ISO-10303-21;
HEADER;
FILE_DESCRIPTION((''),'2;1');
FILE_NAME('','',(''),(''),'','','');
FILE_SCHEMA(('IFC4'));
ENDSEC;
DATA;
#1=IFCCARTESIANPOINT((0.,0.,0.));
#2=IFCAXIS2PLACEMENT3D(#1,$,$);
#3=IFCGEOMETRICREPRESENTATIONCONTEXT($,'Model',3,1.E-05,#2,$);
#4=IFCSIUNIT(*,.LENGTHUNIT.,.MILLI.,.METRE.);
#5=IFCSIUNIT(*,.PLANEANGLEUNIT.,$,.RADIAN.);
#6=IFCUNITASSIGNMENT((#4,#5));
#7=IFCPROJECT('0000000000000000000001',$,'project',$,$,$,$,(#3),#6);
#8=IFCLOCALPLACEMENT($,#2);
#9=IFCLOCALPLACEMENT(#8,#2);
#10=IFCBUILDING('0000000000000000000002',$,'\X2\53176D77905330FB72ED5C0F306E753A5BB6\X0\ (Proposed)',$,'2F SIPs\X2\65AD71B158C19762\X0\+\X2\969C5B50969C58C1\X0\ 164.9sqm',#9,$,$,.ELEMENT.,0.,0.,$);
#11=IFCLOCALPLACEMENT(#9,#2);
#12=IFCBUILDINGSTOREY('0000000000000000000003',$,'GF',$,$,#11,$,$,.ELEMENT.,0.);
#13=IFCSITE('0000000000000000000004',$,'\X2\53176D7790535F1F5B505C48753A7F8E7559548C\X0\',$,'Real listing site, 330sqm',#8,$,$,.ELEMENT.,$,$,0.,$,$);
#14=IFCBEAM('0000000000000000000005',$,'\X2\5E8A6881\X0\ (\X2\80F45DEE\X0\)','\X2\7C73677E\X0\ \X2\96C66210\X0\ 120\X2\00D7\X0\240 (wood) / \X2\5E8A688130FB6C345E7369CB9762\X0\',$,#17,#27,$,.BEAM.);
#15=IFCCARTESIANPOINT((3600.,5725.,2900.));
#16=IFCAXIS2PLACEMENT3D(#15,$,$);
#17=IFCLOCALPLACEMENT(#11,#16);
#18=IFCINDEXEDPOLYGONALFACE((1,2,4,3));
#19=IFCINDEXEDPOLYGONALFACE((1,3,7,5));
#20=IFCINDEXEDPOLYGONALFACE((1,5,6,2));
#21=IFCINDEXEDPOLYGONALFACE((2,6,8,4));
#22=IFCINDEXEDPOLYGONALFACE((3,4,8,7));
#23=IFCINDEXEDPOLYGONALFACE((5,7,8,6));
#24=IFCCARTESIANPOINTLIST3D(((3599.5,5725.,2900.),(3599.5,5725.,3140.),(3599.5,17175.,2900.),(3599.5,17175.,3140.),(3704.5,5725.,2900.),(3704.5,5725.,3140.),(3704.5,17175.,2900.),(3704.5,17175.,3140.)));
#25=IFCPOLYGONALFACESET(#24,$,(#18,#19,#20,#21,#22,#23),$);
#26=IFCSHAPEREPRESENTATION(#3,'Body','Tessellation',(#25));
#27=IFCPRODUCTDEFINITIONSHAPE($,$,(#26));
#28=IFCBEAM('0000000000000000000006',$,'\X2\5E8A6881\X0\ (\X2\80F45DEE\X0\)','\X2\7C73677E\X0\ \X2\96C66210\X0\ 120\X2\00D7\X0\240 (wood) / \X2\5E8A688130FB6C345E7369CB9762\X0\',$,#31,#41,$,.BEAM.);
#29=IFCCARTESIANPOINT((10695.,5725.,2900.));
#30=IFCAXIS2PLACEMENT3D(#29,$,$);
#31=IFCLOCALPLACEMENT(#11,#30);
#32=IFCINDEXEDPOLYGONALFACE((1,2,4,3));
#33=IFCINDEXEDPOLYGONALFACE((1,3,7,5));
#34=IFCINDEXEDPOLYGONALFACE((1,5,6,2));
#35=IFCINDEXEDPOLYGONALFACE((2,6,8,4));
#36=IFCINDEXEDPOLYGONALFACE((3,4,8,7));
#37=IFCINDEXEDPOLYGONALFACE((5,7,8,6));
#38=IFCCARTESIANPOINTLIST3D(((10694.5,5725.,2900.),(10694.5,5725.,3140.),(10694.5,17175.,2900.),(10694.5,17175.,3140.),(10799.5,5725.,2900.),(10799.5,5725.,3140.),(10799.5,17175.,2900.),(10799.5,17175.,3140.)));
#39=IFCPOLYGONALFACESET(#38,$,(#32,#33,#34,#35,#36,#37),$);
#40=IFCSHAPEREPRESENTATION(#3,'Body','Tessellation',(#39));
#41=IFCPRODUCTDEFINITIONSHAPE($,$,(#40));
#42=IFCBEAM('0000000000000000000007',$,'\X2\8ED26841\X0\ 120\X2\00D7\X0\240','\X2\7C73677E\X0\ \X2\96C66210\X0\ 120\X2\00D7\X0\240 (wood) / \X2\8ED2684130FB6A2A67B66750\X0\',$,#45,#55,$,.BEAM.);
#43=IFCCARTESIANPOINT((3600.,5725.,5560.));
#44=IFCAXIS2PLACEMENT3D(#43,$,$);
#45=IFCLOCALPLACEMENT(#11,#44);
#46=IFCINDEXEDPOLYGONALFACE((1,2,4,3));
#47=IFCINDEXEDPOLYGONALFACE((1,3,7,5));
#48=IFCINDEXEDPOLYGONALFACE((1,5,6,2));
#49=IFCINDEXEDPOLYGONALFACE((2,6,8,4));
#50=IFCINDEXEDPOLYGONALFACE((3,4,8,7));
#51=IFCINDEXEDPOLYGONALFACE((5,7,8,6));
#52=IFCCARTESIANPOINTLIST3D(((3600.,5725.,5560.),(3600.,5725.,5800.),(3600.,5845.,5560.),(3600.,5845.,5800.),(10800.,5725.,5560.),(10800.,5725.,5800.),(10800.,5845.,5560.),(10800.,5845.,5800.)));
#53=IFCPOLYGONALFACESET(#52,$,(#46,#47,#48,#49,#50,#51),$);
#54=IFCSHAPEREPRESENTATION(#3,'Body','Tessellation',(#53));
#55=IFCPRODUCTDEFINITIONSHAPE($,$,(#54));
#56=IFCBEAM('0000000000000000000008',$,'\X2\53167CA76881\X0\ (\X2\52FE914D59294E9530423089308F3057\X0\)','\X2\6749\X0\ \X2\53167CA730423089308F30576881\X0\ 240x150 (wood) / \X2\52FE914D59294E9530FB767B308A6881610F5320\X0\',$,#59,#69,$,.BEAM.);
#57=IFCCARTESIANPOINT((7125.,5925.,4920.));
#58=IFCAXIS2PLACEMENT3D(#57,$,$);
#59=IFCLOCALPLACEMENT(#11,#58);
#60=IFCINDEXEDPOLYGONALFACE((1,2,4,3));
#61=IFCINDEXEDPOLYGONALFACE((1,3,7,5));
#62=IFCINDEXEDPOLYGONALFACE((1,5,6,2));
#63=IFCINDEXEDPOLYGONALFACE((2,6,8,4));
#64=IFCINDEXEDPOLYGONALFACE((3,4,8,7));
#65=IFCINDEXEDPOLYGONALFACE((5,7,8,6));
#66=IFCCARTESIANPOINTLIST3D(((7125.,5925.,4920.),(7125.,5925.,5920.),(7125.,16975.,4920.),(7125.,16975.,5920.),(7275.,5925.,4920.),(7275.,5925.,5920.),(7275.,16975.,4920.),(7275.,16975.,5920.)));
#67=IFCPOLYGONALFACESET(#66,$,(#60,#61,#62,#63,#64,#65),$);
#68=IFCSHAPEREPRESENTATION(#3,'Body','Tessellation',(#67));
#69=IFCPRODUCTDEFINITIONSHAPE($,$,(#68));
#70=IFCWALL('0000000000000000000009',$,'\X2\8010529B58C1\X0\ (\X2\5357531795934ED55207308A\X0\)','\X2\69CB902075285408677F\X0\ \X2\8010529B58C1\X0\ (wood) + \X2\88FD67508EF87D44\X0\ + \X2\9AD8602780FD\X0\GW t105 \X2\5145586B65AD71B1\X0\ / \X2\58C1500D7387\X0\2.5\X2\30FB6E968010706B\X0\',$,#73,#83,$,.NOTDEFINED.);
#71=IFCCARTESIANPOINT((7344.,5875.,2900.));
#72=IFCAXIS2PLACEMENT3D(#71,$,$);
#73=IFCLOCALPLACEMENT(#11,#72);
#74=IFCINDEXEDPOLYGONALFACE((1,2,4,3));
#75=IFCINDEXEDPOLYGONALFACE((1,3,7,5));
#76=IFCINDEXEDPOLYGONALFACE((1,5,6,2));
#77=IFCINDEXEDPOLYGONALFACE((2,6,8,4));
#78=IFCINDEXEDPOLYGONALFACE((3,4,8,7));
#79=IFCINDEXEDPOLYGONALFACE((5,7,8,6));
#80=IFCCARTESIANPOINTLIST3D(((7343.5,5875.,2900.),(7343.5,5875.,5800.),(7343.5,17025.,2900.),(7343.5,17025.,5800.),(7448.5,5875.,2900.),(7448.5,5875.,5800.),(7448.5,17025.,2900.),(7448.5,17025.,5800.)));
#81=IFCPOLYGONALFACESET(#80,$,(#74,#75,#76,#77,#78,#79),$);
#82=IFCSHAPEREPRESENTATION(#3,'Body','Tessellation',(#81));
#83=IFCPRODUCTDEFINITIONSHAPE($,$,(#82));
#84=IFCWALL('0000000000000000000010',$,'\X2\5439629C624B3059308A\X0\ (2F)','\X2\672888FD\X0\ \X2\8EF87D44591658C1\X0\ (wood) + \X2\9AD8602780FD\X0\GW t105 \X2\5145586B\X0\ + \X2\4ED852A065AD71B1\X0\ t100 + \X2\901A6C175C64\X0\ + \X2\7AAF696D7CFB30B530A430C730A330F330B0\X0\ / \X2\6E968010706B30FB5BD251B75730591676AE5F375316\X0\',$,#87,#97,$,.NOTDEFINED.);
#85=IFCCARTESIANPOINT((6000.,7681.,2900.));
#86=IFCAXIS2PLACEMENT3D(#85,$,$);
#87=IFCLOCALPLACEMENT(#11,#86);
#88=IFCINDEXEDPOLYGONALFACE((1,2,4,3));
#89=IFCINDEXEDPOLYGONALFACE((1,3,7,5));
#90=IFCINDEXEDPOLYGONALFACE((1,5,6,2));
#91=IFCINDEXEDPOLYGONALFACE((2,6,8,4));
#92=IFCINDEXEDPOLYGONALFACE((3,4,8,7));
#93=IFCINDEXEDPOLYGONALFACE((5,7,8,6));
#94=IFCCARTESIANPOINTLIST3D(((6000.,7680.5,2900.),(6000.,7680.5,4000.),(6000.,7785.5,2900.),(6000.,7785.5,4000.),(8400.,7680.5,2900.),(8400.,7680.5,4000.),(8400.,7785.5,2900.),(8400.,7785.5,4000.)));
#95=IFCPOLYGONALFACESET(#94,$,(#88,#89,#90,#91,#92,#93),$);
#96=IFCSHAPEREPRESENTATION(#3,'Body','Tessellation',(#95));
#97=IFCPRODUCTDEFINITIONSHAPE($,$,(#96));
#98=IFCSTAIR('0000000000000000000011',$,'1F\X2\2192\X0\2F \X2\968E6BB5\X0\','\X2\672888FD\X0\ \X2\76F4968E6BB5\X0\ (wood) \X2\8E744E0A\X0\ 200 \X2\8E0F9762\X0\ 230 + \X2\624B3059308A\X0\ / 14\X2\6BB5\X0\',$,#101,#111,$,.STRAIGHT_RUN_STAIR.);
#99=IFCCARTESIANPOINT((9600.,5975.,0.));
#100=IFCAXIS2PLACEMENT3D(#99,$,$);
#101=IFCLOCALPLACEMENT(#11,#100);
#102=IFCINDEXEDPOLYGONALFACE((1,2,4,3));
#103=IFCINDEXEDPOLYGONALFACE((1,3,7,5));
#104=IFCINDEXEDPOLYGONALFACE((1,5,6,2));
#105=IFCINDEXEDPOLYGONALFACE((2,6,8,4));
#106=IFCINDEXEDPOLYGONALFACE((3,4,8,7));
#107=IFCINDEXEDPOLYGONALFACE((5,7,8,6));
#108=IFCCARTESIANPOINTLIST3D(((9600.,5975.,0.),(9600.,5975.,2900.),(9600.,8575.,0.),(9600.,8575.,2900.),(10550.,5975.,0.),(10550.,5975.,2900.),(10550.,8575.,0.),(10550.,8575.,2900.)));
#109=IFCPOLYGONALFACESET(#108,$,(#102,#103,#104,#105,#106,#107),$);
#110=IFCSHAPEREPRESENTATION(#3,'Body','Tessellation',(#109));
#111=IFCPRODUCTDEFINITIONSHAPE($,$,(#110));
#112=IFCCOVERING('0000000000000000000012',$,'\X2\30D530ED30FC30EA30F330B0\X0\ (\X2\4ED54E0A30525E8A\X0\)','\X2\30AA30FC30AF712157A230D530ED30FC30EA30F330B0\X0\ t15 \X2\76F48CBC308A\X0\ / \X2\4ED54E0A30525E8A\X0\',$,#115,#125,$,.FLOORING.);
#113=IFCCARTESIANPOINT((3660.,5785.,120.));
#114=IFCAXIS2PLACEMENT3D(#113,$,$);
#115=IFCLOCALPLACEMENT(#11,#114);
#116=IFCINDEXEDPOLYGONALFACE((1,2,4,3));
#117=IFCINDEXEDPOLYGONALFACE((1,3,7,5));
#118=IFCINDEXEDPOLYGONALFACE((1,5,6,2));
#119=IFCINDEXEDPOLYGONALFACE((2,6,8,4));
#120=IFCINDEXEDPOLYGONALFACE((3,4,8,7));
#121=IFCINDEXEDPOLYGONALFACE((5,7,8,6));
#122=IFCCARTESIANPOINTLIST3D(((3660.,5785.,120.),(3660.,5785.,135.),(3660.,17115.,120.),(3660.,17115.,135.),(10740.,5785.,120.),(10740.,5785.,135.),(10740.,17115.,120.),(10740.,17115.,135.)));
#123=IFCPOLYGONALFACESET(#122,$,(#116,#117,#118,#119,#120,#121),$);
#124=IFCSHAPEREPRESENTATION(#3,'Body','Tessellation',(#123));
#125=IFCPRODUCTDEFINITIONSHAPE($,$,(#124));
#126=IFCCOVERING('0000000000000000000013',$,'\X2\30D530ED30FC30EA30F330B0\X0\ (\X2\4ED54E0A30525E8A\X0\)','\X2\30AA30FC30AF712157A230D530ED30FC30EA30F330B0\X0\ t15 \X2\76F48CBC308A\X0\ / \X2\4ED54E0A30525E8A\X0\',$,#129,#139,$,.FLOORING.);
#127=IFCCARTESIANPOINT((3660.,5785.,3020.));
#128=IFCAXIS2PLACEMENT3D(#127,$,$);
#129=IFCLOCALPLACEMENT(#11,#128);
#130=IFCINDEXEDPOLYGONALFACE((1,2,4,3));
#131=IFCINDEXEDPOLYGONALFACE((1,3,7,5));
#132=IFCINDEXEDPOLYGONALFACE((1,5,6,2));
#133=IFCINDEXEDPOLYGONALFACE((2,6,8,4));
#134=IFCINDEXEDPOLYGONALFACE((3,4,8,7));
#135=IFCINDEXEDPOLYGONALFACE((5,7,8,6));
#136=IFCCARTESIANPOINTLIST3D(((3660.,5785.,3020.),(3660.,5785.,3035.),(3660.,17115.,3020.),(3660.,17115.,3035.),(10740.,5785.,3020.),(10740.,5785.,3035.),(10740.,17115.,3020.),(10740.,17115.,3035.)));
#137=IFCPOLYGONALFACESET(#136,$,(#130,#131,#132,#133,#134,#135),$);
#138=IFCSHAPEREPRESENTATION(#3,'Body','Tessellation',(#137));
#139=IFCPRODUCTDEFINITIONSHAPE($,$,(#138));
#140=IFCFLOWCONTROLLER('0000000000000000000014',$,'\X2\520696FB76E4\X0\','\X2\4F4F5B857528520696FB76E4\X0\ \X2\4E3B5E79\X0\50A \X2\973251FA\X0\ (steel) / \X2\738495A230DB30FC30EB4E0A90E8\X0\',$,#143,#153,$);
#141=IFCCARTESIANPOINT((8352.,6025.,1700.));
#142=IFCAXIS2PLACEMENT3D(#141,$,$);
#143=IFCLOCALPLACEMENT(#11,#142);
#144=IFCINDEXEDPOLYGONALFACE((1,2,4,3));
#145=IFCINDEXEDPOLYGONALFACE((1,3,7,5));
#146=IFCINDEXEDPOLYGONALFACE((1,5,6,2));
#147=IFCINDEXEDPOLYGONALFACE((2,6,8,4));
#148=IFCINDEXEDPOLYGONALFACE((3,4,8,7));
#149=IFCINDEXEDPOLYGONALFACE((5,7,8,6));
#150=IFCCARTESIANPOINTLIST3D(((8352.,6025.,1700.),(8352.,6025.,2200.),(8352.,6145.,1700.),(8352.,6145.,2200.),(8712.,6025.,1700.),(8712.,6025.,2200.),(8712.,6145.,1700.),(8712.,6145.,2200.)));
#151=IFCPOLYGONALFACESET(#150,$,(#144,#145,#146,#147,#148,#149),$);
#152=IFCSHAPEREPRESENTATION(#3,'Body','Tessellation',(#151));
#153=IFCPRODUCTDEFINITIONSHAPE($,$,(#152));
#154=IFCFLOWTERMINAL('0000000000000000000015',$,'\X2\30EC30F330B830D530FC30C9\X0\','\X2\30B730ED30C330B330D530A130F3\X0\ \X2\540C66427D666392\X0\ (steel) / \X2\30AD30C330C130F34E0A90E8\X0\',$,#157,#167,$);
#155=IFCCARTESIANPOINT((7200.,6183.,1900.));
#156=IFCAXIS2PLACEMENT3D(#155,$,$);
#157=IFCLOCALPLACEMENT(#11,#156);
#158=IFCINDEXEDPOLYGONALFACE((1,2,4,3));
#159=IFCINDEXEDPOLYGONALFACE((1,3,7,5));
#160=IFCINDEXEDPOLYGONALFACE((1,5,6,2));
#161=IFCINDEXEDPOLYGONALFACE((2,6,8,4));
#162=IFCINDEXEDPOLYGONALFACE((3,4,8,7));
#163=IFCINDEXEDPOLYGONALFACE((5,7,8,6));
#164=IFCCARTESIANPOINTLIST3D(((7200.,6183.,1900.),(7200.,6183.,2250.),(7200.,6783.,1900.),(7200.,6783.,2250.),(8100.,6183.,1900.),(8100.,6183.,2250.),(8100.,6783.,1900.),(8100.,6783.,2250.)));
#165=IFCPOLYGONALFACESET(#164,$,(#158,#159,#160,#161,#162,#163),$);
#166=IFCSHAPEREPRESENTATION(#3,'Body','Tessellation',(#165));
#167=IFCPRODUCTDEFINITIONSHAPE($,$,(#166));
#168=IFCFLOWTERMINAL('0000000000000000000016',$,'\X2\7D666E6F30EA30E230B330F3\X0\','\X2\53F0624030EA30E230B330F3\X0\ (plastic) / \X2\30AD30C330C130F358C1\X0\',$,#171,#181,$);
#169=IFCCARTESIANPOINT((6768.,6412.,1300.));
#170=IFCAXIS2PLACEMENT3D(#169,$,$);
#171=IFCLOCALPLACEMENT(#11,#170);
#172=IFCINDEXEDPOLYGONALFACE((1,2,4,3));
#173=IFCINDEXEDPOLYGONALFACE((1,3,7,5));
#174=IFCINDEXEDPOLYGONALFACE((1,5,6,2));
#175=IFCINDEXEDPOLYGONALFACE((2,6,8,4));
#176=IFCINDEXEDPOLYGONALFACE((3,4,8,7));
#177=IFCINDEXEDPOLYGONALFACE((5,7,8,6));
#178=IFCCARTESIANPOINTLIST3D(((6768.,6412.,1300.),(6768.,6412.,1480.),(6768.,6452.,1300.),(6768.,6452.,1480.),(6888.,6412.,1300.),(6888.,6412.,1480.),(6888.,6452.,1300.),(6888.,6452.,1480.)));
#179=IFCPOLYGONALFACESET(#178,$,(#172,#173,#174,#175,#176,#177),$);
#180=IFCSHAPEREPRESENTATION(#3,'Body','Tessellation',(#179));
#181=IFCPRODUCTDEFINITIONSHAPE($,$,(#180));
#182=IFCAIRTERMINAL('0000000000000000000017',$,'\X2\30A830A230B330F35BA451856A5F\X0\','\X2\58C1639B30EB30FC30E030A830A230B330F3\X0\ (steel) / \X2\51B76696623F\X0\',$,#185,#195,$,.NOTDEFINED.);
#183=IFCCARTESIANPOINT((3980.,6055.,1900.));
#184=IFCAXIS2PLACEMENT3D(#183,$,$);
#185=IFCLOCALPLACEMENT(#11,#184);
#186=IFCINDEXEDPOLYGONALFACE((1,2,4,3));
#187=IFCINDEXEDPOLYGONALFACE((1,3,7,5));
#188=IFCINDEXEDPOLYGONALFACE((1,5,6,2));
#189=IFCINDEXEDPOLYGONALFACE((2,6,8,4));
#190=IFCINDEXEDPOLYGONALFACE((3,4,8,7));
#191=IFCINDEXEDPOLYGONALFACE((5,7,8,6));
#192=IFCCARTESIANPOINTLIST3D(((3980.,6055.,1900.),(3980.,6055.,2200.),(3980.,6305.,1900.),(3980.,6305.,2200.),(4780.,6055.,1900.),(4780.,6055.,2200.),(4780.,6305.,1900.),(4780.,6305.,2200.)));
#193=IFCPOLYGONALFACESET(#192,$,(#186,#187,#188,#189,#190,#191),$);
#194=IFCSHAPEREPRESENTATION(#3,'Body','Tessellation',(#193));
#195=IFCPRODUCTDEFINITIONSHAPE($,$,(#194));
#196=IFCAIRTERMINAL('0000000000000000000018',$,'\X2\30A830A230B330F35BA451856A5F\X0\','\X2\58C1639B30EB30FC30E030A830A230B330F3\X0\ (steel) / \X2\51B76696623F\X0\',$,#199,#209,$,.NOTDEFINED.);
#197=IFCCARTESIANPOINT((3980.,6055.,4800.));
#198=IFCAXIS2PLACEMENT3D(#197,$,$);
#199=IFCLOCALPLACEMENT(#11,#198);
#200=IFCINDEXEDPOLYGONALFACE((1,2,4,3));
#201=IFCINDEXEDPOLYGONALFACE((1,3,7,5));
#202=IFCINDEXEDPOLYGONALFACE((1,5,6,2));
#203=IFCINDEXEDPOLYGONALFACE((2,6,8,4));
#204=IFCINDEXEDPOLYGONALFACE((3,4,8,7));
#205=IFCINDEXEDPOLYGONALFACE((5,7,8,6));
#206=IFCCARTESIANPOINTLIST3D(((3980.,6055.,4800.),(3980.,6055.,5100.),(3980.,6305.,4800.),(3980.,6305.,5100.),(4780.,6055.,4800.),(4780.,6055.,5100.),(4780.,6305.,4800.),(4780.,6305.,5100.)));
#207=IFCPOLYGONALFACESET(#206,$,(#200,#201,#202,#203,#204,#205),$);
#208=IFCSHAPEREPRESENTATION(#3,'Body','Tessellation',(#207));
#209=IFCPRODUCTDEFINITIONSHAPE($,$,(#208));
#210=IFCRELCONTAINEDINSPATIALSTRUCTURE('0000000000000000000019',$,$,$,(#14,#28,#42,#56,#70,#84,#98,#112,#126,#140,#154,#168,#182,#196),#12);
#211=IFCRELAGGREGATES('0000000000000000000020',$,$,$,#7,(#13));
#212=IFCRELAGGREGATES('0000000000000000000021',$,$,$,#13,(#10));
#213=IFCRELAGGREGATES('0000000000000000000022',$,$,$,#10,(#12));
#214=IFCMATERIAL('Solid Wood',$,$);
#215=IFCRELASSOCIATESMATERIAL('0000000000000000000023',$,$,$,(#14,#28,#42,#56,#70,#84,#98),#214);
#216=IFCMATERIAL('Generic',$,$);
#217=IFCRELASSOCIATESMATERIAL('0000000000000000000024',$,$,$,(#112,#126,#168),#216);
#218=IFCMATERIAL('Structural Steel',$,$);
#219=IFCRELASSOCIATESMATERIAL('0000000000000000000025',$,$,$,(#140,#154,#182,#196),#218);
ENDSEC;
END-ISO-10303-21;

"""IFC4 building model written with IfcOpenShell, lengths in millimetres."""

from ifc_helpers import new_model, si_unit, frame, frame_2d, origin, place, context, project, spatial, rectangle, extrude, material, element, save


model = new_model("IFC4")

# Units and contexts
model_context = context("Model", 3, precision=1e-05, world=origin())
ifc_project = project(units=[si_unit("LENGTHUNIT", "METRE", prefix="MILLI"), si_unit("PLANEANGLEUNIT", "RADIAN")], contexts=[model_context])

# Site, building, storey
site_placement = place(None, origin())
site = spatial("IfcSite", under=ifc_project, at=site_placement, Name="北海道弟子屈町美留和", ObjectType="Real listing site, 330sqm", CompositionType="ELEMENT", RefElevation=0.0)
building_placement = place(site_placement, origin())
building = spatial("IfcBuilding", under=site, at=building_placement, Name="北海道・狭小の町家 (Proposed)", ObjectType="2F SIPs断熱壁面+障子障壁 164.9sqm", CompositionType="ELEMENT", ElevationOfRefHeight=0.0, ElevationOfTerrain=0.0)
storey_placement = place(building_placement, origin())
storey = spatial("IfcBuildingStorey", under=building, at=storey_placement, Name="GF", CompositionType="ELEMENT", Elevation=0.0)

# Shared definitions
ifc_material_1 = material(Name="Solid Wood")

# Beams
beam_1_placement = place(storey_placement, frame((3600.0, 5725.0, 2900.0)))
element("IfcBeam", 1, at=beam_1_placement, inside=storey, material=ifc_material_1, Name="床梁 (胴差)", Description="米松 集成 120×240 (wood) / 床梁・水平構面", PredefinedType="BEAM", context=model_context, shape_type="SweptSolid", body=[
    extrude(rectangle(XDim=105.0, YDim=11450.0, at=frame_2d((52.0, 5725.0))), frame((3600.0, 5725.0, 2900.0)), (0.0, 0.0, 1.0), 240.0),
])
beam_2_placement = place(storey_placement, frame((10695.0, 5725.0, 2900.0)))
element("IfcBeam", 2, at=beam_2_placement, inside=storey, material=ifc_material_1, Name="床梁 (胴差)", Description="米松 集成 120×240 (wood) / 床梁・水平構面", PredefinedType="BEAM", context=model_context, shape_type="SweptSolid", body=[
    extrude(rectangle(XDim=105.0, YDim=11450.0, at=frame_2d((52.0, 5725.0))), frame((10695.0, 5725.0, 2900.0)), (0.0, 0.0, 1.0), 240.0),
])
beam_3_placement = place(storey_placement, frame((3600.0, 5725.0, 5560.0)))
element("IfcBeam", 3, at=beam_3_placement, inside=storey, material=ifc_material_1, Name="軒桁 120×240", Description="米松 集成 120×240 (wood) / 軒桁・横架材", PredefinedType="BEAM", context=model_context, shape_type="SweptSolid", body=[
    extrude(rectangle(XDim=7200.0, YDim=120.0, at=frame_2d((3600.0, 60.0))), frame((3600.0, 5725.0, 5560.0)), (0.0, 0.0, 1.0), 240.0),
])
beam_4_placement = place(storey_placement, frame((7125.0, 5925.0, 4920.0)))
element("IfcBeam", 4, at=beam_4_placement, inside=storey, material=ifc_material_1, Name="化粧梁 (勾配天井あらわし)", Description="杉 化粧あらわし梁 240x150 (wood) / 勾配天井・登り梁意匠", PredefinedType="BEAM", context=model_context, shape_type="SweptSolid", body=[
    extrude(rectangle(XDim=150.0, YDim=11050.0, at=frame_2d((75.0, 5525.0))), frame((7125.0, 5925.0, 4920.0)), (0.0, 0.0, 1.0), 1000.0),
])

# Walls
wall_1_placement = place(storey_placement, frame((7344.0, 5875.0, 2900.0)))
element("IfcWall", 5, at=wall_1_placement, inside=storey, material=ifc_material_1, Name="耐力壁 (南北間仕切り)", Description="構造用合板 耐力壁 (wood) + 製材軸組 + 高性能GW t105 充填断熱 / 壁倍率2.5・準耐火", PredefinedType="NOTDEFINED", context=model_context, shape_type="SweptSolid", body=[
    extrude(rectangle(XDim=105.0, YDim=11150.0, at=frame_2d((52.0, 5575.0))), frame((7344.0, 5875.0, 2900.0)), (0.0, 0.0, 1.0), 2900.0),
])
wall_2_placement = place(storey_placement, frame((6000.0, 7681.0, 2900.0)))
element("IfcWall", 6, at=wall_2_placement, inside=storey, material=ifc_material_1, Name="吹抜手すり (2F)", Description="木製 軸組外壁 (wood) + 高性能GW t105 充填 + 付加断熱 t100 + 通気層 + 窯業系サイディング / 準耐火・寒冷地外皮強化", PredefinedType="NOTDEFINED", context=model_context, shape_type="SweptSolid", body=[
    extrude(rectangle(XDim=2400.0, YDim=105.0, at=frame_2d((1200.0, 52.0))), frame((6000.0, 7681.0, 2900.0)), (0.0, 0.0, 1.0), 1100.0),
])

# Stair
stair_placement = place(storey_placement, frame((9600.0, 5975.0, 0.0)))
element("IfcStair", 7, at=stair_placement, inside=storey, material=ifc_material_1, Name="1F→2F 階段", Description="木製 直階段 (wood) 蹴上 200 踏面 230 + 手すり / 14段", PredefinedType="STRAIGHT_RUN_STAIR", context=model_context, shape_type="SweptSolid", body=[
    extrude(rectangle(XDim=950.0, YDim=2600.0, at=frame_2d((475.0, 1300.0))), frame((9600.0, 5975.0, 0.0)), (0.0, 0.0, 1.0), 2900.0),
])

# Coverings
ifc_material_2 = material(Name="Generic")
covering_1_placement = place(storey_placement, frame((3660.0, 5785.0, 120.0)))
element("IfcCovering", 8, at=covering_1_placement, inside=storey, material=ifc_material_2, Name="フローリング (仕上げ床)", Description="オーク無垢フローリング t15 直貼り / 仕上げ床", PredefinedType="FLOORING", context=model_context, shape_type="SweptSolid", body=[
    extrude(rectangle(XDim=7080.0, YDim=11330.0, at=frame_2d((3540.0, 5665.0))), frame((3660.0, 5785.0, 120.0)), (0.0, 0.0, 1.0), 15.0),
])
covering_2_placement = place(storey_placement, frame((3660.0, 5785.0, 3020.0)))
element("IfcCovering", 9, at=covering_2_placement, inside=storey, material=ifc_material_2, Name="フローリング (仕上げ床)", Description="オーク無垢フローリング t15 直貼り / 仕上げ床", PredefinedType="FLOORING", context=model_context, shape_type="SweptSolid", body=[
    extrude(rectangle(XDim=7080.0, YDim=11330.0, at=frame_2d((3540.0, 5665.0))), frame((3660.0, 5785.0, 3020.0)), (0.0, 0.0, 1.0), 15.0),
])

# Flow controller
ifc_material_3 = material(Name="Structural Steel")
flow_controller_placement = place(storey_placement, frame((8352.0, 6025.0, 1700.0)))
element("IfcFlowController", 10, at=flow_controller_placement, inside=storey, material=ifc_material_3, Name="分電盤", Description="住宅用分電盤 主幹50A 露出 (steel) / 玄関ホール上部", context=model_context, shape_type="SweptSolid", body=[
    extrude(rectangle(XDim=360.0, YDim=120.0, at=frame_2d((180.0, 60.0))), frame((8352.0, 6025.0, 1700.0)), (0.0, 0.0, 1.0), 500.0),
])

# Flow terminals
flow_terminal_1_placement = place(storey_placement, frame((7200.0, 6183.0, 1900.0)))
element("IfcFlowTerminal", 11, at=flow_terminal_1_placement, inside=storey, material=ifc_material_3, Name="レンジフード", Description="シロッコファン 同時給排 (steel) / キッチン上部", context=model_context, shape_type="SweptSolid", body=[
    extrude(rectangle(XDim=900.0, YDim=600.0, at=frame_2d((450.0, 300.0))), frame((7200.0, 6183.0, 1900.0)), (0.0, 0.0, 1.0), 350.0),
])
flow_terminal_2_placement = place(storey_placement, frame((6768.0, 6412.0, 1300.0)))
element("IfcFlowTerminal", 12, at=flow_terminal_2_placement, inside=storey, material=ifc_material_2, Name="給湯リモコン", Description="台所リモコン (plastic) / キッチン壁", context=model_context, shape_type="SweptSolid", body=[
    extrude(rectangle(XDim=120.0, YDim=40.0, at=frame_2d((60.0, 20.0))), frame((6768.0, 6412.0, 1300.0)), (0.0, 0.0, 1.0), 180.0),
])

# Air terminals
air_terminal_1_placement = place(storey_placement, frame((3980.0, 6055.0, 1900.0)))
element("IfcAirTerminal", 13, at=air_terminal_1_placement, inside=storey, material=ifc_material_3, Name="エアコン室内機", Description="壁掛ルームエアコン (steel) / 冷暖房", PredefinedType="NOTDEFINED", context=model_context, shape_type="SweptSolid", body=[
    extrude(rectangle(XDim=800.0, YDim=250.0, at=frame_2d((400.0, 125.0))), frame((3980.0, 6055.0, 1900.0)), (0.0, 0.0, 1.0), 300.0),
])
air_terminal_2_placement = place(storey_placement, frame((3980.0, 6055.0, 4800.0)))
element("IfcAirTerminal", 14, at=air_terminal_2_placement, inside=storey, material=ifc_material_3, Name="エアコン室内機", Description="壁掛ルームエアコン (steel) / 冷暖房", PredefinedType="NOTDEFINED", context=model_context, shape_type="SweptSolid", body=[
    extrude(rectangle(XDim=800.0, YDim=250.0, at=frame_2d((400.0, 125.0))), frame((3980.0, 6055.0, 4800.0)), (0.0, 0.0, 1.0), 300.0),
])

save(model, "model.ifc")
